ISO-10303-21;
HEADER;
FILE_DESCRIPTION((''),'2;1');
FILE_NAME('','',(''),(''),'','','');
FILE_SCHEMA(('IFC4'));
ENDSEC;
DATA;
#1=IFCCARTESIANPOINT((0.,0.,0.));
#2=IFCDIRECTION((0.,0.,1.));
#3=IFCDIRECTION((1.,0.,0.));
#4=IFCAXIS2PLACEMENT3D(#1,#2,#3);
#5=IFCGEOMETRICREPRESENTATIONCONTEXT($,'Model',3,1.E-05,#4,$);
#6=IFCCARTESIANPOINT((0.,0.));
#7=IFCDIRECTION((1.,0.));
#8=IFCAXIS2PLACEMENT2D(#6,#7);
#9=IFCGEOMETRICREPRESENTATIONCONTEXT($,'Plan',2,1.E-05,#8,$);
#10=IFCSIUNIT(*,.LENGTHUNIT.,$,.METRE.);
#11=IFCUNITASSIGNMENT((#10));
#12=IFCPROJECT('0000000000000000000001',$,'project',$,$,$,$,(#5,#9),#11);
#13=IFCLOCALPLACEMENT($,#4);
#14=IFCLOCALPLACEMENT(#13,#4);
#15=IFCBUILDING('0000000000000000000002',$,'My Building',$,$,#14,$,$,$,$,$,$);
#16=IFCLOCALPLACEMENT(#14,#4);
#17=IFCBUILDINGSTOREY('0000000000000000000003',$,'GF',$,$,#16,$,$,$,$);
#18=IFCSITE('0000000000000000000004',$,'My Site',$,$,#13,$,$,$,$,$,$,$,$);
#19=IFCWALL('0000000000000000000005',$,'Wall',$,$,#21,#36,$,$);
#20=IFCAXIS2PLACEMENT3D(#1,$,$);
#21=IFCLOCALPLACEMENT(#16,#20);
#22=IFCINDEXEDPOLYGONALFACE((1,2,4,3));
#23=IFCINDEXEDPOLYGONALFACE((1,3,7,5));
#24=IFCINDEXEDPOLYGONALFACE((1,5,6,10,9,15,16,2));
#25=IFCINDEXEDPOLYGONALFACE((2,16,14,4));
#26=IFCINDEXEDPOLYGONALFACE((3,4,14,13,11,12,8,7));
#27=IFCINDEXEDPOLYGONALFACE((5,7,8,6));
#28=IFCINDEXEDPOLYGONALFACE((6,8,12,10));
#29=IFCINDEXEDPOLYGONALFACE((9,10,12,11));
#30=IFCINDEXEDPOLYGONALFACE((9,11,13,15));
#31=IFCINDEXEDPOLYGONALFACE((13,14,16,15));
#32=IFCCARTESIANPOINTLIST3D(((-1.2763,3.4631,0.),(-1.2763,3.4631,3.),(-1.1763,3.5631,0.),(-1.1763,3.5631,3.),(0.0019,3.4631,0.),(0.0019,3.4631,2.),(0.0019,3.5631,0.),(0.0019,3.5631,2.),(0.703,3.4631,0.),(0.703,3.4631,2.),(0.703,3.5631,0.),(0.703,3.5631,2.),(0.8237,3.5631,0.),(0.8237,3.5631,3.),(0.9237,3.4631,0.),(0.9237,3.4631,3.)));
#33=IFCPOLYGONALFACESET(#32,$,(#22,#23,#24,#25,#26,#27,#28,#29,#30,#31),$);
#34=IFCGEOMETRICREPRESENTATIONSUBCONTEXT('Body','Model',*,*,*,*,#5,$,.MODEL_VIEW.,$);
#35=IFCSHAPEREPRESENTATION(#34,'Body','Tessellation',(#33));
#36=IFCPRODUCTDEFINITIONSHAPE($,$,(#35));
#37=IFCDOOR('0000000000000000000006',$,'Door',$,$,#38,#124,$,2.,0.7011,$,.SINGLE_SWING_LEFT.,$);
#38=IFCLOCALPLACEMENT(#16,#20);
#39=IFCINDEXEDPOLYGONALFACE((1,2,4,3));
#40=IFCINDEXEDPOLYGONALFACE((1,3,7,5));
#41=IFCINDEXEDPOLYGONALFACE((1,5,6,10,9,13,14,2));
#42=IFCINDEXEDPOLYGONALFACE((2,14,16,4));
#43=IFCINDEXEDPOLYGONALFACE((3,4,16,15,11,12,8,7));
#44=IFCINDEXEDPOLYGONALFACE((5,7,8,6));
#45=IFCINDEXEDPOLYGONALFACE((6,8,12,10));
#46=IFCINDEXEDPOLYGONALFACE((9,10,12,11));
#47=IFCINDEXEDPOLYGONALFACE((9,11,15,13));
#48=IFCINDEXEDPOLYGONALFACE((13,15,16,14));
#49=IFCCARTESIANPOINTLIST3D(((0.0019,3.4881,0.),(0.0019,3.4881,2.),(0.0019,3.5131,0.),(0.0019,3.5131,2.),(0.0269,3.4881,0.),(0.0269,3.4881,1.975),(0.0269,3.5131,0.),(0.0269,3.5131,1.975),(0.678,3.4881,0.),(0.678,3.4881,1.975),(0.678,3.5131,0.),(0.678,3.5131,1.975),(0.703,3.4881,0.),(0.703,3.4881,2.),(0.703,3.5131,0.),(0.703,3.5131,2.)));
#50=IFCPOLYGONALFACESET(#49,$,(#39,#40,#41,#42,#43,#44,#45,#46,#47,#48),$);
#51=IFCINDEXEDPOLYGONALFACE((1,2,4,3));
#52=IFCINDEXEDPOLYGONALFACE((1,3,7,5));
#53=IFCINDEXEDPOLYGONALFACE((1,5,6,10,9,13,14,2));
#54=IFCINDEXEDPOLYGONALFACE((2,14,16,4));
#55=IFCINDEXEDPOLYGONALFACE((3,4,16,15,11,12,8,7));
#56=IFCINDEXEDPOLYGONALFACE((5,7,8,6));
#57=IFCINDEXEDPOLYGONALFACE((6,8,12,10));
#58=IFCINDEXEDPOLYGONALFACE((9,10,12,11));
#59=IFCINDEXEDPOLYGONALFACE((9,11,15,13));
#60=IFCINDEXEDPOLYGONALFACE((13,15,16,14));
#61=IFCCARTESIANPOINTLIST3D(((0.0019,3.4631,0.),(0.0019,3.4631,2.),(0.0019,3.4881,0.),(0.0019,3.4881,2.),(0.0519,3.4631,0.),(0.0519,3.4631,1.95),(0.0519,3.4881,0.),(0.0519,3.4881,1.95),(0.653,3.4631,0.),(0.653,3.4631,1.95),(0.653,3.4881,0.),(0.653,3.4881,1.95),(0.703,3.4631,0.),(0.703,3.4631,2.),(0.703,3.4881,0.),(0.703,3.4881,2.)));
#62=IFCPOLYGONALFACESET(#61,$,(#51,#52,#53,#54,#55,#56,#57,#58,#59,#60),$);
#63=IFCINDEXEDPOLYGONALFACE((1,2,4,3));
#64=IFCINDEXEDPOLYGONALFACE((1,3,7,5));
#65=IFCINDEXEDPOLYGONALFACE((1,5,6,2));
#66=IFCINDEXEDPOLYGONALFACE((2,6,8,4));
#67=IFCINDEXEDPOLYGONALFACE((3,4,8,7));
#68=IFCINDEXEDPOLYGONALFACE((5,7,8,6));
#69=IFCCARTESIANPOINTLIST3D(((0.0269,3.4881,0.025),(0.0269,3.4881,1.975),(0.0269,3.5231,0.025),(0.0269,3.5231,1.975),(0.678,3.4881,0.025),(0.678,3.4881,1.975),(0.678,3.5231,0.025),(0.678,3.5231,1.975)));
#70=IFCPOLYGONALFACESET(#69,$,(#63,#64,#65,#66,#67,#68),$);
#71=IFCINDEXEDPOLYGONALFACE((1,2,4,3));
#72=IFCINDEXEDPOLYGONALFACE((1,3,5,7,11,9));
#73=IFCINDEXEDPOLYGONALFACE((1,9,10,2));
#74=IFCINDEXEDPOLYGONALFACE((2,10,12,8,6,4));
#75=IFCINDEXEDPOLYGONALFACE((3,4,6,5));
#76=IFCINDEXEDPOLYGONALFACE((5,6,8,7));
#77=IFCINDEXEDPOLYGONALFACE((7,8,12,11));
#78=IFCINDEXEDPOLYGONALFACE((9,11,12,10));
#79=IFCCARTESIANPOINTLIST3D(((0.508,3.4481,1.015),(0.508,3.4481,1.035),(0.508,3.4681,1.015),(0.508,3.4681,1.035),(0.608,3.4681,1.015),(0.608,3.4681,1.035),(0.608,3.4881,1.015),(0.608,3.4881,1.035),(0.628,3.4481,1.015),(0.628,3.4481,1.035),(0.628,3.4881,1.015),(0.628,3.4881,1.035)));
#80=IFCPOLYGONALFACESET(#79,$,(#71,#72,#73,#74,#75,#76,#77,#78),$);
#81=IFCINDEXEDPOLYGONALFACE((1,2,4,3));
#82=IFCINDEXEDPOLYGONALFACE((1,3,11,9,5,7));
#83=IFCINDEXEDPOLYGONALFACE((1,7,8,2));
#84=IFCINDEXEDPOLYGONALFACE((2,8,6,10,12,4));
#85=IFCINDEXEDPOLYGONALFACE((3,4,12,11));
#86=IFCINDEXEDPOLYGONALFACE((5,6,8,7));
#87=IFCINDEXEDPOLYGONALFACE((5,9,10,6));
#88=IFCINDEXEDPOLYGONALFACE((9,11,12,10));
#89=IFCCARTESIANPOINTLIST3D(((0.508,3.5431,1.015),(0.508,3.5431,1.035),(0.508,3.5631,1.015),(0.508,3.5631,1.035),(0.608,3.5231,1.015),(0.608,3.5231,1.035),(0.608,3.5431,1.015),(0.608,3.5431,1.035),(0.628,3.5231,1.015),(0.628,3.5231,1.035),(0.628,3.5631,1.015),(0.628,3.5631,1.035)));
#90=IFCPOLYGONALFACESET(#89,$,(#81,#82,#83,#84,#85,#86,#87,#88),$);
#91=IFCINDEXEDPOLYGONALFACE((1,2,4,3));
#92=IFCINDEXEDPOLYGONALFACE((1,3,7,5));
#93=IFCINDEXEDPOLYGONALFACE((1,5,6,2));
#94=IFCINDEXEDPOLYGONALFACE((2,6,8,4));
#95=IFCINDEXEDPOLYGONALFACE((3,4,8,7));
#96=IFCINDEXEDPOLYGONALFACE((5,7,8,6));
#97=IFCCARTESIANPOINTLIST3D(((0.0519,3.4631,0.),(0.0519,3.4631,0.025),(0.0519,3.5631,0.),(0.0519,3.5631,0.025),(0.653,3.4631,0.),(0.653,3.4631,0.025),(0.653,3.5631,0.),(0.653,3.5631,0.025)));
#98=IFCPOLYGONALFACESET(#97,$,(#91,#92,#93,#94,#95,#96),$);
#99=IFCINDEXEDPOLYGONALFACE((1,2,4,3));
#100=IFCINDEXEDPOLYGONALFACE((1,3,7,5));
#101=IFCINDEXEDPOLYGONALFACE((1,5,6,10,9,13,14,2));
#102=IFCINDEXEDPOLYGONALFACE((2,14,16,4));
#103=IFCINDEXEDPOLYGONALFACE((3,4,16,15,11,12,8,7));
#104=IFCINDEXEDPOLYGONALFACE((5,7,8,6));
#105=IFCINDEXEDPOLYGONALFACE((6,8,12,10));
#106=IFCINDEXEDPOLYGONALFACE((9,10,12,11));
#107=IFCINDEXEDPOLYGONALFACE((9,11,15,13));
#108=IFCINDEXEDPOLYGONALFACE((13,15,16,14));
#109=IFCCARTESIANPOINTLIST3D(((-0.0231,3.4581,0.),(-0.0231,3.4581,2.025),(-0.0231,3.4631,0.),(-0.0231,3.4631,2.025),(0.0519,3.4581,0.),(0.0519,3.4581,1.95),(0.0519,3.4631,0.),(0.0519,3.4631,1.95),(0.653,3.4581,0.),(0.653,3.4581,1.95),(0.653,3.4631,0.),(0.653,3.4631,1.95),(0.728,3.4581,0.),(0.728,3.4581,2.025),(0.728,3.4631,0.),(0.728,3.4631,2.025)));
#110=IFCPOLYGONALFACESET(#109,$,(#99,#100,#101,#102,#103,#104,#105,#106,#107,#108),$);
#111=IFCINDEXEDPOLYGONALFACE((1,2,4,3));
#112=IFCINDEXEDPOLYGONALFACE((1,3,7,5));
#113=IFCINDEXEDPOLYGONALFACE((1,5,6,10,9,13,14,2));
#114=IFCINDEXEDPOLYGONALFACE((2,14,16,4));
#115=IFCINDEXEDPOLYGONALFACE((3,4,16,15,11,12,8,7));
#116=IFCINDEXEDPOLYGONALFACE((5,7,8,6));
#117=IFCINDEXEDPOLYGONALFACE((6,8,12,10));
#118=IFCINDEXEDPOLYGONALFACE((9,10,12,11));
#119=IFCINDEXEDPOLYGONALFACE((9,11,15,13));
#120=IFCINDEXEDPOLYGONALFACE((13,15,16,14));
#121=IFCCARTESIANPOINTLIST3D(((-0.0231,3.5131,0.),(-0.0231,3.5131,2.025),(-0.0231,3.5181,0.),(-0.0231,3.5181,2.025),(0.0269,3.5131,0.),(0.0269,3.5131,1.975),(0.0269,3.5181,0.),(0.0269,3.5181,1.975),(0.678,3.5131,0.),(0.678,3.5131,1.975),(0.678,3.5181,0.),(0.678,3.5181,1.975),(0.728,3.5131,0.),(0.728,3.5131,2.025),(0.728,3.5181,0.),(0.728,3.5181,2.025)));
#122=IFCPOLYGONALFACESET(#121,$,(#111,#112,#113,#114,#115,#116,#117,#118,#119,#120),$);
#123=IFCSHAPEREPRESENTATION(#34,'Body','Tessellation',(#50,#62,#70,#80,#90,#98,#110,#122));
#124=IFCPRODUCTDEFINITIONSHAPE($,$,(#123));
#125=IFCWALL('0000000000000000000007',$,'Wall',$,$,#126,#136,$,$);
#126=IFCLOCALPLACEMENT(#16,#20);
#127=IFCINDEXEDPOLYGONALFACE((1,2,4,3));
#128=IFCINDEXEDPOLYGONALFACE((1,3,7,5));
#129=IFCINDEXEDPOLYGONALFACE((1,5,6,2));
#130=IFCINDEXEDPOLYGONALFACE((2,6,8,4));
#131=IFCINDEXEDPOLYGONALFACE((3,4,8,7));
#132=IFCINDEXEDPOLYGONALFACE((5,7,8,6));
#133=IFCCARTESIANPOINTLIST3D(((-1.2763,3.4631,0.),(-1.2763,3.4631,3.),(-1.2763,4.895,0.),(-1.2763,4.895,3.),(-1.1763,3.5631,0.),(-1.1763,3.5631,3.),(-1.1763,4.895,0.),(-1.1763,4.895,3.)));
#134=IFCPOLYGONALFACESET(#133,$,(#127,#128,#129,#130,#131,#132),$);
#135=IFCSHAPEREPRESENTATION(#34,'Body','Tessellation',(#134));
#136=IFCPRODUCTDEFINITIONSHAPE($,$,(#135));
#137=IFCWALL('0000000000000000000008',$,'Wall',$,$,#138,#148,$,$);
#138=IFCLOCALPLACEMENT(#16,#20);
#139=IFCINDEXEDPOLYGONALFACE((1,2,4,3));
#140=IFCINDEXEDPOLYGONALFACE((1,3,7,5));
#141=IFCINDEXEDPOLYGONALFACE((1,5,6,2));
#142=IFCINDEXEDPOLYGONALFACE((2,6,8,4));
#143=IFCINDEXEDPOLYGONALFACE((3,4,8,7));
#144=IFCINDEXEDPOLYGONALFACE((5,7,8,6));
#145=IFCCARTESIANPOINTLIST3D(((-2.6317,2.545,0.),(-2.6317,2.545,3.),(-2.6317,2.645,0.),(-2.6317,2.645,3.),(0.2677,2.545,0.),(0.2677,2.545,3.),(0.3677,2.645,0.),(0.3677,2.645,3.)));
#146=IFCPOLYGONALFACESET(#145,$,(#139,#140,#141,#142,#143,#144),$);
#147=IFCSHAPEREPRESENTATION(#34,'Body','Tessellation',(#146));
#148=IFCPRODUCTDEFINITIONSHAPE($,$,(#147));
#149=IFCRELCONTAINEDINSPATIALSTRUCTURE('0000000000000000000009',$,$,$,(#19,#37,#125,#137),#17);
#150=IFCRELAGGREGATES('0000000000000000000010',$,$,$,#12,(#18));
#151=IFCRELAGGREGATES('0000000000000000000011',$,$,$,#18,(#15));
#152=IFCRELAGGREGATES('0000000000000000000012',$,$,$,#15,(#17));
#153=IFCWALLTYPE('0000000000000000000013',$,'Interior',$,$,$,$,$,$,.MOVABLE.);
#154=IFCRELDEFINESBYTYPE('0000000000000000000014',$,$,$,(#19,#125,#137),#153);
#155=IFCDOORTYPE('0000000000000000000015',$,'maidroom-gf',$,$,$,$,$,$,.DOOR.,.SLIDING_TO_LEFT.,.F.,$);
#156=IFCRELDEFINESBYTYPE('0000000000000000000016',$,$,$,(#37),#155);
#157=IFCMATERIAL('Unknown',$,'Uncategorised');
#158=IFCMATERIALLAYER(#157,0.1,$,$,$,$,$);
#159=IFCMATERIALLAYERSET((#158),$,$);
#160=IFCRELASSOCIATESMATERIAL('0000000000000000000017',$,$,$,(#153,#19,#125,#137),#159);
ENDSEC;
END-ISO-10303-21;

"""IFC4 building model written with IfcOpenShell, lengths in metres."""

from ifc_helpers import new_model, entity, si_unit, frame, origin_with_axes, origin_2d_with_axis, place, context, subcontext, project, spatial, line, indexed_curve, outline, extrude, shape, source, transform, mapped, material, layer, layer_set, layer_usage, type_object, type_shapes, element, fill, save


model = new_model("IFC4")

# Units and contexts
model_context = context("Model", 3, precision=1e-05, world=origin_with_axes())
plan_context = context("Plan", 2, precision=1e-05, world=origin_2d_with_axis())
body_context_1 = subcontext(model_context, "Body", "Model", "MODEL_VIEW")
body_context_2 = subcontext(plan_context, "Body", "Plan", "PLAN_VIEW")
ifc_project = project(units=[si_unit("LENGTHUNIT", "METRE")], contexts=[model_context, plan_context])

# Site, building, storey
site_placement = place(None, origin_with_axes())
site = spatial("IfcSite", under=ifc_project, at=site_placement, Name="My Site")
building_placement = place(site_placement, origin_with_axes())
building = spatial("IfcBuilding", under=site, at=building_placement, Name="My Building")
storey_placement = place(building_placement, origin_with_axes())
storey = spatial("IfcBuildingStorey", under=building, at=storey_placement, Name="GF")

# Shared definitions
ifc_material = material(Name="Unknown", Category="Uncategorised")

# Shared definitions
ifc_layer_1 = layer(ifc_material, 0.1)
ifc_layer_set_1 = layer_set([ifc_layer_1])
wall_type_1 = type_object("IfcWallType", Name="Interior", PredefinedType="MOVABLE", material=ifc_layer_set_1)

# Wall, opening, door
ifc_layer_usage_1 = layer_usage(ifc_layer_set_1, "AXIS2", "POSITIVE", 0.0)
wall_1_placement = place(storey_placement, frame((0.8237, 3.5631, 0.0), z_axis=(0.0, 0.0, 1.0), x_axis=(-1.0, 0.0, 0.0)))
wall_1 = element("IfcWall", 1, at=wall_1_placement, inside=storey, type_object=wall_type_1, material=ifc_layer_usage_1, Name="Wall", context=body_context_1, shape_type="SweptSolid", body=[
    extrude(outline(indexed_curve([(0.0, 0.0), (-0.1, 0.1), (2.1, 0.1), (2.0, 0.0)], segments=[line(1, 2, 3, 4, 1)])), origin_with_axes(), (0.0, 0.0, 1.0), 3.0),
])
shared_shape_1 = source(origin_with_axes(), body_context_1, "Body", "SweptSolid", [
    extrude(outline(indexed_curve([(0.0, 0.0), (0.7011, 0.0), (0.7011, 2.0), (0.0, 2.0)], segments=[line(1, 2, 3, 4, 1)])), frame((0.0, -0.6, 0.0), z_axis=(0.0, -1.0, 0.0), x_axis=(1.0, 0.0, 0.0)), (0.0, 0.0, -1.0), 1.2),
])
opening_1_placement = place(wall_1_placement, frame((0.8218, 0.1, 0.0), z_axis=(0.0, 0.0, 1.0), x_axis=(-1.0, 0.0, 0.0)))
opening_1 = element("IfcOpeningElement", 2, at=opening_1_placement, cuts=wall_1, PredefinedType="OPENING", context=body_context_1, shape_type="MappedRepresentation", body=[
    mapped(shared_shape_1, transform((0.0, 0.0, 0.0), x_axis=(1.0, 0.0, 0.0), y_axis=(0.0, 1.0, 0.0), z_axis=(0.0, 0.0, 1.0), scale=1.0)),
])
door_type_1 = type_object("IfcDoorType", Name="maidroom-gf", OperationType="SLIDING_TO_LEFT", ParameterTakesPrecedence=False, PredefinedType="DOOR")
shared_shape_2 = source(origin_with_axes(), body_context_1, "Body", "SweptSolid", [
    extrude(outline(indexed_curve([(0.0, 0.0), (0.0, 2.0), (0.7011, 2.0), (0.7011, 0.0), (0.6761, 0.0), (0.6761, 1.975), (0.025, 1.975), (0.025, 0.0)], segments=[line(1, 2, 3, 4, 5, 6, 7, 8, 1)])), frame((0.0, 0.025, 0.0), z_axis=(0.0, -1.0, 0.0), x_axis=(1.0, 0.0, 0.0)), (0.0, 0.0, -1.0), 0.025),
    extrude(outline(indexed_curve([(0.0, 0.0), (0.0, 2.0), (0.7011, 2.0), (0.7011, 0.0), (0.6511, 0.0), (0.6511, 1.95), (0.05, 1.95), (0.05, 0.0)], segments=[line(1, 2, 3, 4, 5, 6, 7, 8, 1)])), frame((0.0, 0.0, 0.0), z_axis=(0.0, -1.0, 0.0), x_axis=(1.0, 0.0, 0.0)), (0.0, 0.0, -1.0), 0.025),
    extrude(outline(indexed_curve([(0.0, 0.0), (0.6511, 0.0), (0.6511, 0.035), (0.0, 0.035)], segments=[line(1, 2, 3, 4, 1)])), frame((0.025, 0.025, 0.025), z_axis=(0.0, 0.0, 1.0), x_axis=(1.0, 0.0, 0.0)), (0.0, 0.0, 1.0), 1.95),
    extrude(outline(indexed_curve([(0.0, 0.0), (0.0, -0.04), (-0.12, -0.04), (-0.12, -0.02), (-0.02, -0.02), (-0.02, 0.0)], segments=[line(1, 2, 3, 4, 5, 6, 1)])), frame((0.6261, 0.025, 1.015), z_axis=(0.0, 0.0, 1.0), x_axis=(1.0, 0.0, 0.0)), (0.0, 0.0, 1.0), 0.02),
    extrude(outline(indexed_curve([(0.0, 0.0), (0.0, 0.04), (-0.12, 0.04), (-0.12, 0.02), (-0.02, 0.02), (-0.02, 0.0)], segments=[line(1, 2, 3, 4, 5, 6, 1)])), frame((0.6261, 0.06, 1.015), z_axis=(0.0, 0.0, 1.0), x_axis=(1.0, 0.0, 0.0)), (0.0, 0.0, 1.0), 0.02),
    extrude(outline(indexed_curve([(0.0, 0.0), (0.6011, 0.0), (0.6011, 0.1), (0.0, 0.1)], segments=[line(1, 2, 3, 4, 1)])), frame((0.05, 0.0, 0.0), z_axis=(0.0, 0.0, 1.0), x_axis=(1.0, 0.0, 0.0)), (0.0, 0.0, 1.0), 0.025),
    extrude(outline(indexed_curve([(0.0, 0.0), (0.0, 2.025), (0.7511, 2.025), (0.7511, 0.0), (0.6761, 0.0), (0.6761, 1.95), (0.075, 1.95), (0.075, 0.0)], segments=[line(1, 2, 3, 4, 5, 6, 7, 8, 1)])), frame((-0.025, -0.005, 0.0), z_axis=(0.0, -1.0, 0.0), x_axis=(1.0, 0.0, 0.0)), (0.0, 0.0, -1.0), 0.005),
    extrude(outline(indexed_curve([(0.0, 0.0), (0.0, 2.025), (0.7511, 2.025), (0.7511, 0.0), (0.7011, 0.0), (0.7011, 1.975), (0.05, 1.975), (0.05, 0.0)], segments=[line(1, 2, 3, 4, 5, 6, 7, 8, 1)])), frame((-0.025, 0.05, 0.0), z_axis=(0.0, -1.0, 0.0), x_axis=(1.0, 0.0, 0.0)), (0.0, 0.0, -1.0), 0.005),
])
shared_shape_3 = source(origin_with_axes(), body_context_2, "Body", "Curve2D", [
    entity("IfcIndexedPolyCurve", entity("IfcCartesianPointList2D", [[0.0, 0.0], [0.0, 0.05], [0.025, 0.05], [0.025, 0.025], [0.05, 0.025], [0.05, 0.0]]), [entity("IfcLineIndex", [1, 2, 3, 4, 5, 6, 1])]),
    entity("IfcIndexedPolyCurve", entity("IfcCartesianPointList2D", [[0.7011, 0.0], [0.7011, 0.05], [0.6761, 0.05], [0.6761, 0.025], [0.6511, 0.025], [0.6511, 0.0]]), [entity("IfcLineIndex", [1, 2, 3, 4, 5, 6, 1])]),
    entity("IfcTrimmedCurve", entity("IfcEllipse", entity("IfcAxis2Placement2D", entity("IfcCartesianPoint", [0.06, 0.05]), entity("IfcDirection", [1.0, 0.0])), 0.6161, 0.6511), [entity("IfcCartesianPoint", [0.6761, 0.05])], [entity("IfcCartesianPoint", [0.06, 0.7011])], True, "CARTESIAN"),
    entity("IfcIndexedPolyCurve", entity("IfcCartesianPointList2D", [[0.025, 0.05], [0.06, 0.05], [0.06, 0.7011], [0.025, 0.7011]]), [entity("IfcLineIndex", [1, 2, 3, 4, 1])]),
])
type_shapes(door_type_1, [shared_shape_2, shared_shape_3])
door_1_placement = place(opening_1_placement, frame((0.0, 0.0, 0.0), z_axis=(0.0, 0.0, 1.0), x_axis=(1.0, 0.0, 0.0)))
door_1 = element("IfcDoor", 3, at=door_1_placement, inside=storey, type_object=door_type_1, Name="Door", OperationType="SINGLE_SWING_LEFT", OverallHeight=2.0, OverallWidth=0.7011, shapes=[
    shape(body_context_1, "Body", "MappedRepresentation", [mapped(shared_shape_2, transform((0.0, 0.0, 0.0), x_axis=(1.0, 0.0, 0.0), y_axis=(0.0, 1.0, 0.0), z_axis=(0.0, 0.0, 1.0), scale=1.0))]),
    shape(body_context_2, "Body", "MappedRepresentation", [mapped(shared_shape_3, transform((0.0, 0.0, 0.0), x_axis=(1.0, 0.0, 0.0), y_axis=(0.0, 1.0, 0.0), z_axis=(0.0, 0.0, 1.0), scale=1.0))]),
])
fill(opening_1, door_1)

# Walls
ifc_layer_usage_2 = layer_usage(ifc_layer_set_1, "AXIS2", "POSITIVE", 0.0)
wall_2_placement = place(storey_placement, frame((-1.1763, 3.5631, 0.0), z_axis=(0.0, 0.0, 1.0), x_axis=(0.0, 1.0, 0.0)))
element("IfcWall", 4, at=wall_2_placement, inside=storey, type_object=wall_type_1, material=ifc_layer_usage_2, Name="Wall", context=body_context_1, shape_type="SweptSolid", body=[
    extrude(outline(indexed_curve([(0.0, 0.0), (-0.1, 0.1), (1.3318, 0.1), (1.3318, 0.0)], segments=[line(1, 2, 3, 4, 1)])), origin_with_axes(), (0.0, 0.0, 1.0), 3.0),
])
ifc_layer_usage_3 = layer_usage(ifc_layer_set_1, "AXIS2", "POSITIVE", 0.0)
wall_3_placement = place(storey_placement, frame((0.3677, 2.645, 0.0), z_axis=(0.0, 0.0, 1.0), x_axis=(-1.0, 0.0, 0.0)))
element("IfcWall", 5, at=wall_3_placement, inside=storey, type_object=wall_type_1, material=ifc_layer_usage_3, Name="Wall", context=body_context_1, shape_type="SweptSolid", body=[
    extrude(outline(indexed_curve([(0.0, 0.0), (0.1, 0.1), (2.9994, 0.1), (2.9994, 0.0)], segments=[line(1, 2, 3, 4, 1)])), origin_with_axes(), (0.0, 0.0, 1.0), 3.0),
])

save(model, "model.ifc")
